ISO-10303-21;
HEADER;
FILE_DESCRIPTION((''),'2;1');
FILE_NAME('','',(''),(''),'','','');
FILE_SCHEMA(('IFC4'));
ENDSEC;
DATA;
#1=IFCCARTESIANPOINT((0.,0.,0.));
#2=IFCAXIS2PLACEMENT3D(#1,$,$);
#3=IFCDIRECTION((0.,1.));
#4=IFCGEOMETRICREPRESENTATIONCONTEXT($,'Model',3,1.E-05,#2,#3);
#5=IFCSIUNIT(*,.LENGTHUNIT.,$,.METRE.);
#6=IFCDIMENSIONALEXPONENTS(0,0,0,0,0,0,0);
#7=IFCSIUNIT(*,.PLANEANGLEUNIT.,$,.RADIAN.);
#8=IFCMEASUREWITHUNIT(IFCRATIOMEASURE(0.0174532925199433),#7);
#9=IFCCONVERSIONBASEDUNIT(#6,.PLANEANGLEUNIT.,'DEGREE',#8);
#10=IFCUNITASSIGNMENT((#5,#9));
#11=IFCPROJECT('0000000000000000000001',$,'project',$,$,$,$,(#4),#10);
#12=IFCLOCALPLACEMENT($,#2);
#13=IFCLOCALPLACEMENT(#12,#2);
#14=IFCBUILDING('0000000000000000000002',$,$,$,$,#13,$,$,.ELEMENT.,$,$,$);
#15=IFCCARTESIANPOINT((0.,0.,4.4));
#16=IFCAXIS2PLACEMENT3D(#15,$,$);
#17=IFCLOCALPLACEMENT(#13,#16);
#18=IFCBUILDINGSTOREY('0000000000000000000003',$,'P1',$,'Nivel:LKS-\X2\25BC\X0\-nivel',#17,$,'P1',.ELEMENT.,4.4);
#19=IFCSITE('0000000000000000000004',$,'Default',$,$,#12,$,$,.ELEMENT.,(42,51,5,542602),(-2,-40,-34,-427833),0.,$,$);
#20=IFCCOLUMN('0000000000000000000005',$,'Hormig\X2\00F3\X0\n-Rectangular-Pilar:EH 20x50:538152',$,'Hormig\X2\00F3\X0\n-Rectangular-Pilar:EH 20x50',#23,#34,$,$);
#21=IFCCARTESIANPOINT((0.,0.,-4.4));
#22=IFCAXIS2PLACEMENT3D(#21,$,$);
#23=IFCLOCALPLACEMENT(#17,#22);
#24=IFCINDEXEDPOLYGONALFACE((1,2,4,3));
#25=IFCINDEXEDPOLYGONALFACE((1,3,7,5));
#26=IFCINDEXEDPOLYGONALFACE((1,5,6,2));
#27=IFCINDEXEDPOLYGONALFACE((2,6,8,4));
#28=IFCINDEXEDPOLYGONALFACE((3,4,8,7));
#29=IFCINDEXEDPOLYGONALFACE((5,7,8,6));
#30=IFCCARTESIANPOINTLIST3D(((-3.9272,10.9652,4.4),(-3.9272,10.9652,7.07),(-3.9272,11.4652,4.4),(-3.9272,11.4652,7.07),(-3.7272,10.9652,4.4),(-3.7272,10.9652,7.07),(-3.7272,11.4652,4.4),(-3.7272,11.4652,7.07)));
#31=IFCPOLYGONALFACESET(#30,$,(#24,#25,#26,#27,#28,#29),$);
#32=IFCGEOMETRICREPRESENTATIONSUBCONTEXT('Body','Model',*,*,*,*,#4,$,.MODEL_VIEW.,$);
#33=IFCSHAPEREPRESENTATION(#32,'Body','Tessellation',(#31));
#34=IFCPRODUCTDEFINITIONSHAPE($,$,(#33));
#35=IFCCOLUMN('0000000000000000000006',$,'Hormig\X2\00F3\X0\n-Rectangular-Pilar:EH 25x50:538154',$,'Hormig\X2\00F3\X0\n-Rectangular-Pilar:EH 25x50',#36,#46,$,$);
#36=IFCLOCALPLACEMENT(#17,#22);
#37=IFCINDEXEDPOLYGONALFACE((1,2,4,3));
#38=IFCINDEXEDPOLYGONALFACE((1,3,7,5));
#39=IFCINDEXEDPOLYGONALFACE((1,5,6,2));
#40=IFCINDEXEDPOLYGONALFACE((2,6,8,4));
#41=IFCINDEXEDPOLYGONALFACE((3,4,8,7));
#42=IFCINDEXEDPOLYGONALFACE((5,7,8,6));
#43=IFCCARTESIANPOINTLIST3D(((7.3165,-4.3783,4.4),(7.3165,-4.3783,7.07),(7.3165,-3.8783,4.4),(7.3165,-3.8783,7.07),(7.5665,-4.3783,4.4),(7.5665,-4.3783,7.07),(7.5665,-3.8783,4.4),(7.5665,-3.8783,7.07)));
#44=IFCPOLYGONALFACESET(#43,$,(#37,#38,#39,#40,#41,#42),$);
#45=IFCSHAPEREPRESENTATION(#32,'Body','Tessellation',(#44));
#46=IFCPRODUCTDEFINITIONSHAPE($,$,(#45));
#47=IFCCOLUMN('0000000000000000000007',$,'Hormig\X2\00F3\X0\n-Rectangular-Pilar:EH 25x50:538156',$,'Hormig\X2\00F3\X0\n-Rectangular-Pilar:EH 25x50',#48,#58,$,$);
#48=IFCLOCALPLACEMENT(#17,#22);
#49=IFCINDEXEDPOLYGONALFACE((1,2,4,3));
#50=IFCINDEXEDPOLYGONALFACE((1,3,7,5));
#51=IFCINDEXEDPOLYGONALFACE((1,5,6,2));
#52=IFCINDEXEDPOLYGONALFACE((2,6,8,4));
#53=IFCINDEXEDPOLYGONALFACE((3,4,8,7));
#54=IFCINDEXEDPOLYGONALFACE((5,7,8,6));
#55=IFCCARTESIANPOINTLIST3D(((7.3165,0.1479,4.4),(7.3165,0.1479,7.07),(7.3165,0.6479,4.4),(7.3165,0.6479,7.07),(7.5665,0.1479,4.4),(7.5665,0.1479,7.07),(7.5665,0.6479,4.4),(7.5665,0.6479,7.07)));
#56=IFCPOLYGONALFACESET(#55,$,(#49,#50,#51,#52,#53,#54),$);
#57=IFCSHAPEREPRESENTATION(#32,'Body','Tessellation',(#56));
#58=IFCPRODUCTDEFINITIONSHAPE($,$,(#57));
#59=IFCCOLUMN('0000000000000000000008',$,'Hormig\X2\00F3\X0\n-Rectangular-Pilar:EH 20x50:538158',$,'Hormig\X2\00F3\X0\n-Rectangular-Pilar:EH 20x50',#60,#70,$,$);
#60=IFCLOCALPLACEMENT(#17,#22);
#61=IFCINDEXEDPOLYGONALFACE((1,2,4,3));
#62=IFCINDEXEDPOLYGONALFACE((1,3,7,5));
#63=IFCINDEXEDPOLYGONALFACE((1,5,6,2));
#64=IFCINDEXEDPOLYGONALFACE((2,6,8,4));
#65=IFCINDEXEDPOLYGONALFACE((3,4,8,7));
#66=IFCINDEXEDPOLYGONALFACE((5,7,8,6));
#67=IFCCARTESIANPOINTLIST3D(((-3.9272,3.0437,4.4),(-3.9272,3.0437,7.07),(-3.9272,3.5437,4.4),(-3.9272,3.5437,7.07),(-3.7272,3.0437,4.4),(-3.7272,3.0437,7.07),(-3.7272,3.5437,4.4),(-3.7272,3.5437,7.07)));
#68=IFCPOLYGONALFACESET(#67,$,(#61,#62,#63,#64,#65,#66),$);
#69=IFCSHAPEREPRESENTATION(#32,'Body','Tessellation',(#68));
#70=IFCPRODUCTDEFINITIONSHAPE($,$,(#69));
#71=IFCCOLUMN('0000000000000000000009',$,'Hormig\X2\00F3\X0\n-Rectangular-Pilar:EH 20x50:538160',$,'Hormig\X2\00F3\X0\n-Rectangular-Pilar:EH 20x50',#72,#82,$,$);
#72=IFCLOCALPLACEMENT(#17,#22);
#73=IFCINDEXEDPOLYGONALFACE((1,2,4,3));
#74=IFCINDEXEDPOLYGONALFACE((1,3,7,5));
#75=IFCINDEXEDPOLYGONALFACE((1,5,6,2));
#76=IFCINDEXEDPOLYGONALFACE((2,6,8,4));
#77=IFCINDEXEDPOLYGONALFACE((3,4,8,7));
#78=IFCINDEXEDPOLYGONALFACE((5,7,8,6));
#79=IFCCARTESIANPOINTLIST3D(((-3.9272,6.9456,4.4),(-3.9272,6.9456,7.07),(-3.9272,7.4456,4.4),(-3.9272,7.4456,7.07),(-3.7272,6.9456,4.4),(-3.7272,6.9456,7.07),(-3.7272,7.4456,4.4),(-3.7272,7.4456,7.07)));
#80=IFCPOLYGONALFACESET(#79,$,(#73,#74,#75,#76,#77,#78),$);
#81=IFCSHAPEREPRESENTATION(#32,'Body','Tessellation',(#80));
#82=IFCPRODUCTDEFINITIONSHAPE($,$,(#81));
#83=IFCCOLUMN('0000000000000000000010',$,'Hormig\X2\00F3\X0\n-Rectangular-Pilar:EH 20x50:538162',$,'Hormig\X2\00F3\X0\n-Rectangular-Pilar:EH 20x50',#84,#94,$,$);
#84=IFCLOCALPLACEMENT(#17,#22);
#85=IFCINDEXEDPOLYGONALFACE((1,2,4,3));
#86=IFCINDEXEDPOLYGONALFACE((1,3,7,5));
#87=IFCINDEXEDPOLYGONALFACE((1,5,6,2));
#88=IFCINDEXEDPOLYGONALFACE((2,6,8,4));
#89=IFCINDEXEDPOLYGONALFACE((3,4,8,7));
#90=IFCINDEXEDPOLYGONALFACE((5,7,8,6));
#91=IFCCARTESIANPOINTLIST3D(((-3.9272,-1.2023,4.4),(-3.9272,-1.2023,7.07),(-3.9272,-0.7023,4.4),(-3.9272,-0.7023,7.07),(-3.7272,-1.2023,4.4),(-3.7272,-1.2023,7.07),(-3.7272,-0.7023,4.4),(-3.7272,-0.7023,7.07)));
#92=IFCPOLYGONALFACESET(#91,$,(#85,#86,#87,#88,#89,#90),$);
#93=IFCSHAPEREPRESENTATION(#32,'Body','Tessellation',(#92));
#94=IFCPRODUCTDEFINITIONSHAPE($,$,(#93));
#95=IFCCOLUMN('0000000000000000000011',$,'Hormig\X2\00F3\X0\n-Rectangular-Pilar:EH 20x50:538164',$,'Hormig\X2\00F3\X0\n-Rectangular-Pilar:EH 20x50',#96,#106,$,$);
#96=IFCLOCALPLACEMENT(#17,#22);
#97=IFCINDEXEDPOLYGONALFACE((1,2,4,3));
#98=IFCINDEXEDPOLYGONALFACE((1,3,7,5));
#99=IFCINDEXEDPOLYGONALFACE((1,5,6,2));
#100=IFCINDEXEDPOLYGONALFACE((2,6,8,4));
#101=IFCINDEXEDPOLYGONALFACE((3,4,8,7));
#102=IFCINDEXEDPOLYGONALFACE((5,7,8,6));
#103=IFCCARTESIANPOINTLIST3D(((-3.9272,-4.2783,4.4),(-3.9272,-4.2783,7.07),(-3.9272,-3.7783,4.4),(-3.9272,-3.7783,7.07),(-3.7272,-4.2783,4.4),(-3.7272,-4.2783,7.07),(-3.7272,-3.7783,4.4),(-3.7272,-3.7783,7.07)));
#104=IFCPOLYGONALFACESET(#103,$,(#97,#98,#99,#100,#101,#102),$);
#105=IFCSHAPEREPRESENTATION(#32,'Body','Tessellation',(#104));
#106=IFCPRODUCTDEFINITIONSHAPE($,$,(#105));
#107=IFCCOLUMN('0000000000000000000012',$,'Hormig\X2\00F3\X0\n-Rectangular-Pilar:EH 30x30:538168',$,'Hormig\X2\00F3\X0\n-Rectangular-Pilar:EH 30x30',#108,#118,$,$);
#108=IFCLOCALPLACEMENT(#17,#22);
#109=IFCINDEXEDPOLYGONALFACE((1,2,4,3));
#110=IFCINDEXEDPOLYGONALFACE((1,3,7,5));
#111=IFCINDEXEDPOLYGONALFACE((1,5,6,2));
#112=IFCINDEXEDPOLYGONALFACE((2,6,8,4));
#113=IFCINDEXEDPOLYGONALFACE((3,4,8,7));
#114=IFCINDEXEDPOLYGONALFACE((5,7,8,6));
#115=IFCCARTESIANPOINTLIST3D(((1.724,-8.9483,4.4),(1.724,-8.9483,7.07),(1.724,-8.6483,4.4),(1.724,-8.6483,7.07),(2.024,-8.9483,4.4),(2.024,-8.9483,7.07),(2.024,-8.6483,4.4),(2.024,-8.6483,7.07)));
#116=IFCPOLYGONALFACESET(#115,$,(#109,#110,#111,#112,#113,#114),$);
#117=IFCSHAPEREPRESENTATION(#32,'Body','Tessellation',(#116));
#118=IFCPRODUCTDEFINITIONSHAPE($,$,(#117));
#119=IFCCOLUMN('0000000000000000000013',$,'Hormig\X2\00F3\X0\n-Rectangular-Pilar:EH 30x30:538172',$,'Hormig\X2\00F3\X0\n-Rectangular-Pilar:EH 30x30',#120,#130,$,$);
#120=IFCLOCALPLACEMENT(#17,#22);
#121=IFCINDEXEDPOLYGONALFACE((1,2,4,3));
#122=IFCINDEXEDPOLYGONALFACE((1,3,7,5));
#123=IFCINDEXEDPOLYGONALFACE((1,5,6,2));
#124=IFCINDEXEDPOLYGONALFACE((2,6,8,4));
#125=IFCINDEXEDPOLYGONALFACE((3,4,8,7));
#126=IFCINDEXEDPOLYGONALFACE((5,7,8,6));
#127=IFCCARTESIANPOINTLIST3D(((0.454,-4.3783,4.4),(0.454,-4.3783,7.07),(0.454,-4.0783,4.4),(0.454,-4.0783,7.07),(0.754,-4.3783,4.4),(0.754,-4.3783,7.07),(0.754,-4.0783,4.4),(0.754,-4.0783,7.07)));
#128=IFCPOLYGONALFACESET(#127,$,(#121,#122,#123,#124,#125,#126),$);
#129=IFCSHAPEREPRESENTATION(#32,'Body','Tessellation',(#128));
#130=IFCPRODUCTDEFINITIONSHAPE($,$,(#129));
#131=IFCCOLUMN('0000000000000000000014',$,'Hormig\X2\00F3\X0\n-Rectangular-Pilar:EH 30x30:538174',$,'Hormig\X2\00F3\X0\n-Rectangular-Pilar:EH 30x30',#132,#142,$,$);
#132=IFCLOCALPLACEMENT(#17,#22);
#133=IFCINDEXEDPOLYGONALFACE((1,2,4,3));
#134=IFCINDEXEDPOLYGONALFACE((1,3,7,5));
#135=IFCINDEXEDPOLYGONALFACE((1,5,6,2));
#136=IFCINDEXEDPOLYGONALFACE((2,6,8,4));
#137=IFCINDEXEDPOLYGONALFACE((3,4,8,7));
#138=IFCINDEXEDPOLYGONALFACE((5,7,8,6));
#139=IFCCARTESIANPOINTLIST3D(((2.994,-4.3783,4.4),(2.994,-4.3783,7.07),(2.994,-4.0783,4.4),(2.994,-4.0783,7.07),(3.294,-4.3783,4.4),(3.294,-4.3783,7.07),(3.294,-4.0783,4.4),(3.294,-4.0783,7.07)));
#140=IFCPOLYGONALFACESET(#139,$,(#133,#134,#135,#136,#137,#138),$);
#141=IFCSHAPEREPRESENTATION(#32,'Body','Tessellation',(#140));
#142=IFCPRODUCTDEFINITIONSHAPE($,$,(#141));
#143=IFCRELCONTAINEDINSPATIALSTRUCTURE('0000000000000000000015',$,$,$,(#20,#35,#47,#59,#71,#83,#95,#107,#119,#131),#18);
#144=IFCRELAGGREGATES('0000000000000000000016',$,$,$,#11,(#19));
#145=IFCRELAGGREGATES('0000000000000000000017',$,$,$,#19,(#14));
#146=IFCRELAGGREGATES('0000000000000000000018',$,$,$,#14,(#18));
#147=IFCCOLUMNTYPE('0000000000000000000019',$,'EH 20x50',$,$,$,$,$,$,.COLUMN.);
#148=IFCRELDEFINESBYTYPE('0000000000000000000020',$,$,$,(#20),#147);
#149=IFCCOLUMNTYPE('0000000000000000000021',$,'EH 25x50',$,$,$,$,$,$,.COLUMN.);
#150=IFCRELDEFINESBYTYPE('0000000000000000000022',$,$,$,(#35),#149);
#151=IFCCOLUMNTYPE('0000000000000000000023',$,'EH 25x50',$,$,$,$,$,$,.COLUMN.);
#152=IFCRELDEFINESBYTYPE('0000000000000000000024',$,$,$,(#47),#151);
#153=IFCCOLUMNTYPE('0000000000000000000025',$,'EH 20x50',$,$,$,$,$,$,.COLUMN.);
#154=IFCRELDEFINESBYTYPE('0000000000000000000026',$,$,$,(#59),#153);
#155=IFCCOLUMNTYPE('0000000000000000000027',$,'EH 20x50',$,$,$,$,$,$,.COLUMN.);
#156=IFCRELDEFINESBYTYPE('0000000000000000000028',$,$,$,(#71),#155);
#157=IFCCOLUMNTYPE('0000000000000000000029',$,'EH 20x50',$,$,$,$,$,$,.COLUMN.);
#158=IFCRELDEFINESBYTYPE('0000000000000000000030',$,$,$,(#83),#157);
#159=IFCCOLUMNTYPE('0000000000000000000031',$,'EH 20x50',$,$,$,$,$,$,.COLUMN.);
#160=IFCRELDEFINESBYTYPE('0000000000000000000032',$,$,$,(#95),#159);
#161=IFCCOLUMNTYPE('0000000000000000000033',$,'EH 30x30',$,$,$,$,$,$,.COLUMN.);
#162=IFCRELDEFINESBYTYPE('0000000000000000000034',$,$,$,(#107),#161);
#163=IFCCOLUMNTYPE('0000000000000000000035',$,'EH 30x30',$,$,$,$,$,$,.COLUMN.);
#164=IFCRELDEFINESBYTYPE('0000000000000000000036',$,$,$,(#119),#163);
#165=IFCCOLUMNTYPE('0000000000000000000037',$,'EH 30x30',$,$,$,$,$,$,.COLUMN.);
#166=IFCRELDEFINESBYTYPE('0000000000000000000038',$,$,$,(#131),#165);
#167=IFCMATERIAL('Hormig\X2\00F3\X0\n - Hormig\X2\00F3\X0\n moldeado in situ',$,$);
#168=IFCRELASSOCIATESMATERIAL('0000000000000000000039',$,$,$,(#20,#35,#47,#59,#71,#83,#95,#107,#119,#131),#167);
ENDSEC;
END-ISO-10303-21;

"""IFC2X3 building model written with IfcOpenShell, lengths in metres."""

from ifc_helpers import new_model, entity, si_unit, converted_unit, direction, frame, frame_2d, origin, origin_2d_with_axis, place, context, subcontext, project, spatial, rectangle, extrude, source, transform, mapped, material, type_object, type_shapes, element, save


model = new_model("IFC2X3")

# Units and contexts
model_context = context("Model", 3, precision=1e-05, world=origin(), true_north=direction((0.0, 1.0)))
body_context = subcontext(model_context, "Body", "Model", "MODEL_VIEW")
ifc_project = project(units=[si_unit("LENGTHUNIT", "METRE"), converted_unit("PLANEANGLEUNIT", "DEGREE", entity("IfcRatioMeasure", 0.0174532925199433), si_unit("PLANEANGLEUNIT", "RADIAN"), dimensions=[0, 0, 0, 0, 0, 0, 0])], contexts=[model_context])

# Site, building, storey
site_placement = place(None, origin())
site = spatial("IfcSite", under=ifc_project, at=site_placement, Name="Default", CompositionType="ELEMENT", RefLatitude=(42, 51, 5, 542602), RefLongitude=(-2, -40, -34, -427833), RefElevation=0.0)
building_placement = place(site_placement, origin())
building = spatial("IfcBuilding", under=site, at=building_placement, CompositionType="ELEMENT")
storey_placement = place(building_placement, frame((0.0, 0.0, 4.4)))
storey = spatial("IfcBuildingStorey", under=building, at=storey_placement, Name="P1", ObjectType="Nivel:LKS-▼-nivel", LongName="P1", CompositionType="ELEMENT", Elevation=4.4)

# Columns
ifc_material_1 = material(Name="Hormigón - Hormigón moldeado in situ")
column_type_1 = type_object("IfcColumnType", Name="EH 20x50", PredefinedType="COLUMN")
shared_shape_1 = source(origin(), body_context, "Body", "SweptSolid", [
    extrude(rectangle(XDim=0.5, YDim=0.2, at=origin_2d_with_axis()), frame((-3.8272, 11.2152, 4.4), z_axis=(0.0, 0.0, 1.0), x_axis=(0.0, -1.0, 0.0)), (0.0, 0.0, 1.0), 2.67),
])
type_shapes(column_type_1, [shared_shape_1])
column_1_placement = place(storey_placement, frame((0.0, 0.0, -4.4)))
element("IfcColumn", 1, at=column_1_placement, inside=storey, type_object=column_type_1, material=ifc_material_1, Name="Hormigón-Rectangular-Pilar:EH 20x50:538152", ObjectType="Hormigón-Rectangular-Pilar:EH 20x50", context=body_context, shape_type="MappedRepresentation", body=[
    mapped(shared_shape_1, transform((0.0, 0.0, 0.0), scale=1.0)),
])
column_type_2 = type_object("IfcColumnType", Name="EH 25x50", PredefinedType="COLUMN")
shared_shape_2 = source(origin(), body_context, "Body", "SweptSolid", [
    extrude(rectangle(XDim=0.5, YDim=0.25, at=origin_2d_with_axis()), frame((7.4415, -4.1283, 4.4), z_axis=(0.0, 0.0, 1.0), x_axis=(0.0, -1.0, 0.0)), (0.0, 0.0, 1.0), 2.67),
])
type_shapes(column_type_2, [shared_shape_2])
column_2_placement = place(storey_placement, frame((0.0, 0.0, -4.4)))
element("IfcColumn", 2, at=column_2_placement, inside=storey, type_object=column_type_2, material=ifc_material_1, Name="Hormigón-Rectangular-Pilar:EH 25x50:538154", ObjectType="Hormigón-Rectangular-Pilar:EH 25x50", context=body_context, shape_type="MappedRepresentation", body=[
    mapped(shared_shape_2, transform((0.0, 0.0, 0.0), scale=1.0)),
])
column_type_3 = type_object("IfcColumnType", Name="EH 25x50", PredefinedType="COLUMN")
shared_shape_3 = source(origin(), body_context, "Body", "SweptSolid", [
    extrude(rectangle(XDim=0.5, YDim=0.25, at=origin_2d_with_axis()), frame((7.4415, 0.3979, 4.4), z_axis=(0.0, 0.0, 1.0), x_axis=(0.0, -1.0, 0.0)), (0.0, 0.0, 1.0), 2.67),
])
type_shapes(column_type_3, [shared_shape_3])
column_3_placement = place(storey_placement, frame((0.0, 0.0, -4.4)))
element("IfcColumn", 3, at=column_3_placement, inside=storey, type_object=column_type_3, material=ifc_material_1, Name="Hormigón-Rectangular-Pilar:EH 25x50:538156", ObjectType="Hormigón-Rectangular-Pilar:EH 25x50", context=body_context, shape_type="MappedRepresentation", body=[
    mapped(shared_shape_3, transform((0.0, 0.0, 0.0), scale=1.0)),
])
column_type_4 = type_object("IfcColumnType", Name="EH 20x50", PredefinedType="COLUMN")
shared_shape_4 = source(origin(), body_context, "Body", "SweptSolid", [
    extrude(rectangle(XDim=0.5, YDim=0.2, at=origin_2d_with_axis()), frame((-3.8272, 3.2937, 4.4), z_axis=(0.0, 0.0, 1.0), x_axis=(0.0, -1.0, 0.0)), (0.0, 0.0, 1.0), 2.67),
])
type_shapes(column_type_4, [shared_shape_4])
column_4_placement = place(storey_placement, frame((0.0, 0.0, -4.4)))
element("IfcColumn", 4, at=column_4_placement, inside=storey, type_object=column_type_4, material=ifc_material_1, Name="Hormigón-Rectangular-Pilar:EH 20x50:538158", ObjectType="Hormigón-Rectangular-Pilar:EH 20x50", context=body_context, shape_type="MappedRepresentation", body=[
    mapped(shared_shape_4, transform((0.0, 0.0, 0.0), scale=1.0)),
])
column_type_5 = type_object("IfcColumnType", Name="EH 20x50", PredefinedType="COLUMN")
shared_shape_5 = source(origin(), body_context, "Body", "SweptSolid", [
    extrude(rectangle(XDim=0.5, YDim=0.2, at=origin_2d_with_axis()), frame((-3.8272, 7.1956, 4.4), z_axis=(0.0, 0.0, 1.0), x_axis=(0.0, -1.0, 0.0)), (0.0, 0.0, 1.0), 2.67),
])
type_shapes(column_type_5, [shared_shape_5])
column_5_placement = place(storey_placement, frame((0.0, 0.0, -4.4)))
element("IfcColumn", 5, at=column_5_placement, inside=storey, type_object=column_type_5, material=ifc_material_1, Name="Hormigón-Rectangular-Pilar:EH 20x50:538160", ObjectType="Hormigón-Rectangular-Pilar:EH 20x50", context=body_context, shape_type="MappedRepresentation", body=[
    mapped(shared_shape_5, transform((0.0, 0.0, 0.0), scale=1.0)),
])
column_type_6 = type_object("IfcColumnType", Name="EH 20x50", PredefinedType="COLUMN")
shared_shape_6 = source(origin(), body_context, "Body", "SweptSolid", [
    extrude(rectangle(XDim=0.5, YDim=0.2, at=frame_2d((0.0, 0.0), x_axis=(1.0, 0.0))), frame((-3.8272, -0.9523, 4.4), z_axis=(0.0, 0.0, 1.0), x_axis=(0.0, -1.0, 0.0)), (0.0, 0.0, 1.0), 2.67),
])
type_shapes(column_type_6, [shared_shape_6])
column_6_placement = place(storey_placement, frame((0.0, 0.0, -4.4)))
element("IfcColumn", 6, at=column_6_placement, inside=storey, type_object=column_type_6, material=ifc_material_1, Name="Hormigón-Rectangular-Pilar:EH 20x50:538162", ObjectType="Hormigón-Rectangular-Pilar:EH 20x50", context=body_context, shape_type="MappedRepresentation", body=[
    mapped(shared_shape_6, transform((0.0, 0.0, 0.0), scale=1.0)),
])
column_type_7 = type_object("IfcColumnType", Name="EH 20x50", PredefinedType="COLUMN")
shared_shape_7 = source(origin(), body_context, "Body", "SweptSolid", [
    extrude(rectangle(XDim=0.5, YDim=0.2, at=origin_2d_with_axis()), frame((-3.8272, -4.0283, 4.4), z_axis=(0.0, 0.0, 1.0), x_axis=(0.0, -1.0, 0.0)), (0.0, 0.0, 1.0), 2.67),
])
type_shapes(column_type_7, [shared_shape_7])
column_7_placement = place(storey_placement, frame((0.0, 0.0, -4.4)))
element("IfcColumn", 7, at=column_7_placement, inside=storey, type_object=column_type_7, material=ifc_material_1, Name="Hormigón-Rectangular-Pilar:EH 20x50:538164", ObjectType="Hormigón-Rectangular-Pilar:EH 20x50", context=body_context, shape_type="MappedRepresentation", body=[
    mapped(shared_shape_7, transform((0.0, 0.0, 0.0), scale=1.0)),
])
column_type_8 = type_object("IfcColumnType", Name="EH 30x30", PredefinedType="COLUMN")
shared_shape_8 = source(origin(), body_context, "Body", "SweptSolid", [
    extrude(rectangle(XDim=0.3, YDim=0.3, at=frame_2d((0.0, 0.0), x_axis=(1.0, 0.0))), frame((1.874, -8.7983, 4.4), z_axis=(0.0, 0.0, 1.0), x_axis=(0.0, -1.0, 0.0)), (0.0, 0.0, 1.0), 2.67),
])
type_shapes(column_type_8, [shared_shape_8])
column_8_placement = place(storey_placement, frame((0.0, 0.0, -4.4)))
element("IfcColumn", 8, at=column_8_placement, inside=storey, type_object=column_type_8, material=ifc_material_1, Name="Hormigón-Rectangular-Pilar:EH 30x30:538168", ObjectType="Hormigón-Rectangular-Pilar:EH 30x30", context=body_context, shape_type="MappedRepresentation", body=[
    mapped(shared_shape_8, transform((0.0, 0.0, 0.0), scale=1.0)),
])
column_type_9 = type_object("IfcColumnType", Name="EH 30x30", PredefinedType="COLUMN")
shared_shape_9 = source(origin(), body_context, "Body", "SweptSolid", [
    extrude(rectangle(XDim=0.3, YDim=0.3, at=frame_2d((0.0, 0.0), x_axis=(1.0, 0.0))), frame((0.604, -4.2283, 4.4), z_axis=(0.0, 0.0, 1.0), x_axis=(0.0, -1.0, 0.0)), (0.0, 0.0, 1.0), 2.67),
])
type_shapes(column_type_9, [shared_shape_9])
column_9_placement = place(storey_placement, frame((0.0, 0.0, -4.4)))
element("IfcColumn", 9, at=column_9_placement, inside=storey, type_object=column_type_9, material=ifc_material_1, Name="Hormigón-Rectangular-Pilar:EH 30x30:538172", ObjectType="Hormigón-Rectangular-Pilar:EH 30x30", context=body_context, shape_type="MappedRepresentation", body=[
    mapped(shared_shape_9, transform((0.0, 0.0, 0.0), scale=1.0)),
])
column_type_10 = type_object("IfcColumnType", Name="EH 30x30", PredefinedType="COLUMN")
shared_shape_10 = source(origin(), body_context, "Body", "SweptSolid", [
    extrude(rectangle(XDim=0.3, YDim=0.3, at=origin_2d_with_axis()), frame((3.144, -4.2283, 4.4), z_axis=(0.0, 0.0, 1.0), x_axis=(0.0, -1.0, 0.0)), (0.0, 0.0, 1.0), 2.67),
])
type_shapes(column_type_10, [shared_shape_10])
column_10_placement = place(storey_placement, frame((0.0, 0.0, -4.4)))
element("IfcColumn", 10, at=column_10_placement, inside=storey, type_object=column_type_10, material=ifc_material_1, Name="Hormigón-Rectangular-Pilar:EH 30x30:538174", ObjectType="Hormigón-Rectangular-Pilar:EH 30x30", context=body_context, shape_type="MappedRepresentation", body=[
    mapped(shared_shape_10, transform((0.0, 0.0, 0.0), scale=1.0)),
])

save(model, "model.ifc")
